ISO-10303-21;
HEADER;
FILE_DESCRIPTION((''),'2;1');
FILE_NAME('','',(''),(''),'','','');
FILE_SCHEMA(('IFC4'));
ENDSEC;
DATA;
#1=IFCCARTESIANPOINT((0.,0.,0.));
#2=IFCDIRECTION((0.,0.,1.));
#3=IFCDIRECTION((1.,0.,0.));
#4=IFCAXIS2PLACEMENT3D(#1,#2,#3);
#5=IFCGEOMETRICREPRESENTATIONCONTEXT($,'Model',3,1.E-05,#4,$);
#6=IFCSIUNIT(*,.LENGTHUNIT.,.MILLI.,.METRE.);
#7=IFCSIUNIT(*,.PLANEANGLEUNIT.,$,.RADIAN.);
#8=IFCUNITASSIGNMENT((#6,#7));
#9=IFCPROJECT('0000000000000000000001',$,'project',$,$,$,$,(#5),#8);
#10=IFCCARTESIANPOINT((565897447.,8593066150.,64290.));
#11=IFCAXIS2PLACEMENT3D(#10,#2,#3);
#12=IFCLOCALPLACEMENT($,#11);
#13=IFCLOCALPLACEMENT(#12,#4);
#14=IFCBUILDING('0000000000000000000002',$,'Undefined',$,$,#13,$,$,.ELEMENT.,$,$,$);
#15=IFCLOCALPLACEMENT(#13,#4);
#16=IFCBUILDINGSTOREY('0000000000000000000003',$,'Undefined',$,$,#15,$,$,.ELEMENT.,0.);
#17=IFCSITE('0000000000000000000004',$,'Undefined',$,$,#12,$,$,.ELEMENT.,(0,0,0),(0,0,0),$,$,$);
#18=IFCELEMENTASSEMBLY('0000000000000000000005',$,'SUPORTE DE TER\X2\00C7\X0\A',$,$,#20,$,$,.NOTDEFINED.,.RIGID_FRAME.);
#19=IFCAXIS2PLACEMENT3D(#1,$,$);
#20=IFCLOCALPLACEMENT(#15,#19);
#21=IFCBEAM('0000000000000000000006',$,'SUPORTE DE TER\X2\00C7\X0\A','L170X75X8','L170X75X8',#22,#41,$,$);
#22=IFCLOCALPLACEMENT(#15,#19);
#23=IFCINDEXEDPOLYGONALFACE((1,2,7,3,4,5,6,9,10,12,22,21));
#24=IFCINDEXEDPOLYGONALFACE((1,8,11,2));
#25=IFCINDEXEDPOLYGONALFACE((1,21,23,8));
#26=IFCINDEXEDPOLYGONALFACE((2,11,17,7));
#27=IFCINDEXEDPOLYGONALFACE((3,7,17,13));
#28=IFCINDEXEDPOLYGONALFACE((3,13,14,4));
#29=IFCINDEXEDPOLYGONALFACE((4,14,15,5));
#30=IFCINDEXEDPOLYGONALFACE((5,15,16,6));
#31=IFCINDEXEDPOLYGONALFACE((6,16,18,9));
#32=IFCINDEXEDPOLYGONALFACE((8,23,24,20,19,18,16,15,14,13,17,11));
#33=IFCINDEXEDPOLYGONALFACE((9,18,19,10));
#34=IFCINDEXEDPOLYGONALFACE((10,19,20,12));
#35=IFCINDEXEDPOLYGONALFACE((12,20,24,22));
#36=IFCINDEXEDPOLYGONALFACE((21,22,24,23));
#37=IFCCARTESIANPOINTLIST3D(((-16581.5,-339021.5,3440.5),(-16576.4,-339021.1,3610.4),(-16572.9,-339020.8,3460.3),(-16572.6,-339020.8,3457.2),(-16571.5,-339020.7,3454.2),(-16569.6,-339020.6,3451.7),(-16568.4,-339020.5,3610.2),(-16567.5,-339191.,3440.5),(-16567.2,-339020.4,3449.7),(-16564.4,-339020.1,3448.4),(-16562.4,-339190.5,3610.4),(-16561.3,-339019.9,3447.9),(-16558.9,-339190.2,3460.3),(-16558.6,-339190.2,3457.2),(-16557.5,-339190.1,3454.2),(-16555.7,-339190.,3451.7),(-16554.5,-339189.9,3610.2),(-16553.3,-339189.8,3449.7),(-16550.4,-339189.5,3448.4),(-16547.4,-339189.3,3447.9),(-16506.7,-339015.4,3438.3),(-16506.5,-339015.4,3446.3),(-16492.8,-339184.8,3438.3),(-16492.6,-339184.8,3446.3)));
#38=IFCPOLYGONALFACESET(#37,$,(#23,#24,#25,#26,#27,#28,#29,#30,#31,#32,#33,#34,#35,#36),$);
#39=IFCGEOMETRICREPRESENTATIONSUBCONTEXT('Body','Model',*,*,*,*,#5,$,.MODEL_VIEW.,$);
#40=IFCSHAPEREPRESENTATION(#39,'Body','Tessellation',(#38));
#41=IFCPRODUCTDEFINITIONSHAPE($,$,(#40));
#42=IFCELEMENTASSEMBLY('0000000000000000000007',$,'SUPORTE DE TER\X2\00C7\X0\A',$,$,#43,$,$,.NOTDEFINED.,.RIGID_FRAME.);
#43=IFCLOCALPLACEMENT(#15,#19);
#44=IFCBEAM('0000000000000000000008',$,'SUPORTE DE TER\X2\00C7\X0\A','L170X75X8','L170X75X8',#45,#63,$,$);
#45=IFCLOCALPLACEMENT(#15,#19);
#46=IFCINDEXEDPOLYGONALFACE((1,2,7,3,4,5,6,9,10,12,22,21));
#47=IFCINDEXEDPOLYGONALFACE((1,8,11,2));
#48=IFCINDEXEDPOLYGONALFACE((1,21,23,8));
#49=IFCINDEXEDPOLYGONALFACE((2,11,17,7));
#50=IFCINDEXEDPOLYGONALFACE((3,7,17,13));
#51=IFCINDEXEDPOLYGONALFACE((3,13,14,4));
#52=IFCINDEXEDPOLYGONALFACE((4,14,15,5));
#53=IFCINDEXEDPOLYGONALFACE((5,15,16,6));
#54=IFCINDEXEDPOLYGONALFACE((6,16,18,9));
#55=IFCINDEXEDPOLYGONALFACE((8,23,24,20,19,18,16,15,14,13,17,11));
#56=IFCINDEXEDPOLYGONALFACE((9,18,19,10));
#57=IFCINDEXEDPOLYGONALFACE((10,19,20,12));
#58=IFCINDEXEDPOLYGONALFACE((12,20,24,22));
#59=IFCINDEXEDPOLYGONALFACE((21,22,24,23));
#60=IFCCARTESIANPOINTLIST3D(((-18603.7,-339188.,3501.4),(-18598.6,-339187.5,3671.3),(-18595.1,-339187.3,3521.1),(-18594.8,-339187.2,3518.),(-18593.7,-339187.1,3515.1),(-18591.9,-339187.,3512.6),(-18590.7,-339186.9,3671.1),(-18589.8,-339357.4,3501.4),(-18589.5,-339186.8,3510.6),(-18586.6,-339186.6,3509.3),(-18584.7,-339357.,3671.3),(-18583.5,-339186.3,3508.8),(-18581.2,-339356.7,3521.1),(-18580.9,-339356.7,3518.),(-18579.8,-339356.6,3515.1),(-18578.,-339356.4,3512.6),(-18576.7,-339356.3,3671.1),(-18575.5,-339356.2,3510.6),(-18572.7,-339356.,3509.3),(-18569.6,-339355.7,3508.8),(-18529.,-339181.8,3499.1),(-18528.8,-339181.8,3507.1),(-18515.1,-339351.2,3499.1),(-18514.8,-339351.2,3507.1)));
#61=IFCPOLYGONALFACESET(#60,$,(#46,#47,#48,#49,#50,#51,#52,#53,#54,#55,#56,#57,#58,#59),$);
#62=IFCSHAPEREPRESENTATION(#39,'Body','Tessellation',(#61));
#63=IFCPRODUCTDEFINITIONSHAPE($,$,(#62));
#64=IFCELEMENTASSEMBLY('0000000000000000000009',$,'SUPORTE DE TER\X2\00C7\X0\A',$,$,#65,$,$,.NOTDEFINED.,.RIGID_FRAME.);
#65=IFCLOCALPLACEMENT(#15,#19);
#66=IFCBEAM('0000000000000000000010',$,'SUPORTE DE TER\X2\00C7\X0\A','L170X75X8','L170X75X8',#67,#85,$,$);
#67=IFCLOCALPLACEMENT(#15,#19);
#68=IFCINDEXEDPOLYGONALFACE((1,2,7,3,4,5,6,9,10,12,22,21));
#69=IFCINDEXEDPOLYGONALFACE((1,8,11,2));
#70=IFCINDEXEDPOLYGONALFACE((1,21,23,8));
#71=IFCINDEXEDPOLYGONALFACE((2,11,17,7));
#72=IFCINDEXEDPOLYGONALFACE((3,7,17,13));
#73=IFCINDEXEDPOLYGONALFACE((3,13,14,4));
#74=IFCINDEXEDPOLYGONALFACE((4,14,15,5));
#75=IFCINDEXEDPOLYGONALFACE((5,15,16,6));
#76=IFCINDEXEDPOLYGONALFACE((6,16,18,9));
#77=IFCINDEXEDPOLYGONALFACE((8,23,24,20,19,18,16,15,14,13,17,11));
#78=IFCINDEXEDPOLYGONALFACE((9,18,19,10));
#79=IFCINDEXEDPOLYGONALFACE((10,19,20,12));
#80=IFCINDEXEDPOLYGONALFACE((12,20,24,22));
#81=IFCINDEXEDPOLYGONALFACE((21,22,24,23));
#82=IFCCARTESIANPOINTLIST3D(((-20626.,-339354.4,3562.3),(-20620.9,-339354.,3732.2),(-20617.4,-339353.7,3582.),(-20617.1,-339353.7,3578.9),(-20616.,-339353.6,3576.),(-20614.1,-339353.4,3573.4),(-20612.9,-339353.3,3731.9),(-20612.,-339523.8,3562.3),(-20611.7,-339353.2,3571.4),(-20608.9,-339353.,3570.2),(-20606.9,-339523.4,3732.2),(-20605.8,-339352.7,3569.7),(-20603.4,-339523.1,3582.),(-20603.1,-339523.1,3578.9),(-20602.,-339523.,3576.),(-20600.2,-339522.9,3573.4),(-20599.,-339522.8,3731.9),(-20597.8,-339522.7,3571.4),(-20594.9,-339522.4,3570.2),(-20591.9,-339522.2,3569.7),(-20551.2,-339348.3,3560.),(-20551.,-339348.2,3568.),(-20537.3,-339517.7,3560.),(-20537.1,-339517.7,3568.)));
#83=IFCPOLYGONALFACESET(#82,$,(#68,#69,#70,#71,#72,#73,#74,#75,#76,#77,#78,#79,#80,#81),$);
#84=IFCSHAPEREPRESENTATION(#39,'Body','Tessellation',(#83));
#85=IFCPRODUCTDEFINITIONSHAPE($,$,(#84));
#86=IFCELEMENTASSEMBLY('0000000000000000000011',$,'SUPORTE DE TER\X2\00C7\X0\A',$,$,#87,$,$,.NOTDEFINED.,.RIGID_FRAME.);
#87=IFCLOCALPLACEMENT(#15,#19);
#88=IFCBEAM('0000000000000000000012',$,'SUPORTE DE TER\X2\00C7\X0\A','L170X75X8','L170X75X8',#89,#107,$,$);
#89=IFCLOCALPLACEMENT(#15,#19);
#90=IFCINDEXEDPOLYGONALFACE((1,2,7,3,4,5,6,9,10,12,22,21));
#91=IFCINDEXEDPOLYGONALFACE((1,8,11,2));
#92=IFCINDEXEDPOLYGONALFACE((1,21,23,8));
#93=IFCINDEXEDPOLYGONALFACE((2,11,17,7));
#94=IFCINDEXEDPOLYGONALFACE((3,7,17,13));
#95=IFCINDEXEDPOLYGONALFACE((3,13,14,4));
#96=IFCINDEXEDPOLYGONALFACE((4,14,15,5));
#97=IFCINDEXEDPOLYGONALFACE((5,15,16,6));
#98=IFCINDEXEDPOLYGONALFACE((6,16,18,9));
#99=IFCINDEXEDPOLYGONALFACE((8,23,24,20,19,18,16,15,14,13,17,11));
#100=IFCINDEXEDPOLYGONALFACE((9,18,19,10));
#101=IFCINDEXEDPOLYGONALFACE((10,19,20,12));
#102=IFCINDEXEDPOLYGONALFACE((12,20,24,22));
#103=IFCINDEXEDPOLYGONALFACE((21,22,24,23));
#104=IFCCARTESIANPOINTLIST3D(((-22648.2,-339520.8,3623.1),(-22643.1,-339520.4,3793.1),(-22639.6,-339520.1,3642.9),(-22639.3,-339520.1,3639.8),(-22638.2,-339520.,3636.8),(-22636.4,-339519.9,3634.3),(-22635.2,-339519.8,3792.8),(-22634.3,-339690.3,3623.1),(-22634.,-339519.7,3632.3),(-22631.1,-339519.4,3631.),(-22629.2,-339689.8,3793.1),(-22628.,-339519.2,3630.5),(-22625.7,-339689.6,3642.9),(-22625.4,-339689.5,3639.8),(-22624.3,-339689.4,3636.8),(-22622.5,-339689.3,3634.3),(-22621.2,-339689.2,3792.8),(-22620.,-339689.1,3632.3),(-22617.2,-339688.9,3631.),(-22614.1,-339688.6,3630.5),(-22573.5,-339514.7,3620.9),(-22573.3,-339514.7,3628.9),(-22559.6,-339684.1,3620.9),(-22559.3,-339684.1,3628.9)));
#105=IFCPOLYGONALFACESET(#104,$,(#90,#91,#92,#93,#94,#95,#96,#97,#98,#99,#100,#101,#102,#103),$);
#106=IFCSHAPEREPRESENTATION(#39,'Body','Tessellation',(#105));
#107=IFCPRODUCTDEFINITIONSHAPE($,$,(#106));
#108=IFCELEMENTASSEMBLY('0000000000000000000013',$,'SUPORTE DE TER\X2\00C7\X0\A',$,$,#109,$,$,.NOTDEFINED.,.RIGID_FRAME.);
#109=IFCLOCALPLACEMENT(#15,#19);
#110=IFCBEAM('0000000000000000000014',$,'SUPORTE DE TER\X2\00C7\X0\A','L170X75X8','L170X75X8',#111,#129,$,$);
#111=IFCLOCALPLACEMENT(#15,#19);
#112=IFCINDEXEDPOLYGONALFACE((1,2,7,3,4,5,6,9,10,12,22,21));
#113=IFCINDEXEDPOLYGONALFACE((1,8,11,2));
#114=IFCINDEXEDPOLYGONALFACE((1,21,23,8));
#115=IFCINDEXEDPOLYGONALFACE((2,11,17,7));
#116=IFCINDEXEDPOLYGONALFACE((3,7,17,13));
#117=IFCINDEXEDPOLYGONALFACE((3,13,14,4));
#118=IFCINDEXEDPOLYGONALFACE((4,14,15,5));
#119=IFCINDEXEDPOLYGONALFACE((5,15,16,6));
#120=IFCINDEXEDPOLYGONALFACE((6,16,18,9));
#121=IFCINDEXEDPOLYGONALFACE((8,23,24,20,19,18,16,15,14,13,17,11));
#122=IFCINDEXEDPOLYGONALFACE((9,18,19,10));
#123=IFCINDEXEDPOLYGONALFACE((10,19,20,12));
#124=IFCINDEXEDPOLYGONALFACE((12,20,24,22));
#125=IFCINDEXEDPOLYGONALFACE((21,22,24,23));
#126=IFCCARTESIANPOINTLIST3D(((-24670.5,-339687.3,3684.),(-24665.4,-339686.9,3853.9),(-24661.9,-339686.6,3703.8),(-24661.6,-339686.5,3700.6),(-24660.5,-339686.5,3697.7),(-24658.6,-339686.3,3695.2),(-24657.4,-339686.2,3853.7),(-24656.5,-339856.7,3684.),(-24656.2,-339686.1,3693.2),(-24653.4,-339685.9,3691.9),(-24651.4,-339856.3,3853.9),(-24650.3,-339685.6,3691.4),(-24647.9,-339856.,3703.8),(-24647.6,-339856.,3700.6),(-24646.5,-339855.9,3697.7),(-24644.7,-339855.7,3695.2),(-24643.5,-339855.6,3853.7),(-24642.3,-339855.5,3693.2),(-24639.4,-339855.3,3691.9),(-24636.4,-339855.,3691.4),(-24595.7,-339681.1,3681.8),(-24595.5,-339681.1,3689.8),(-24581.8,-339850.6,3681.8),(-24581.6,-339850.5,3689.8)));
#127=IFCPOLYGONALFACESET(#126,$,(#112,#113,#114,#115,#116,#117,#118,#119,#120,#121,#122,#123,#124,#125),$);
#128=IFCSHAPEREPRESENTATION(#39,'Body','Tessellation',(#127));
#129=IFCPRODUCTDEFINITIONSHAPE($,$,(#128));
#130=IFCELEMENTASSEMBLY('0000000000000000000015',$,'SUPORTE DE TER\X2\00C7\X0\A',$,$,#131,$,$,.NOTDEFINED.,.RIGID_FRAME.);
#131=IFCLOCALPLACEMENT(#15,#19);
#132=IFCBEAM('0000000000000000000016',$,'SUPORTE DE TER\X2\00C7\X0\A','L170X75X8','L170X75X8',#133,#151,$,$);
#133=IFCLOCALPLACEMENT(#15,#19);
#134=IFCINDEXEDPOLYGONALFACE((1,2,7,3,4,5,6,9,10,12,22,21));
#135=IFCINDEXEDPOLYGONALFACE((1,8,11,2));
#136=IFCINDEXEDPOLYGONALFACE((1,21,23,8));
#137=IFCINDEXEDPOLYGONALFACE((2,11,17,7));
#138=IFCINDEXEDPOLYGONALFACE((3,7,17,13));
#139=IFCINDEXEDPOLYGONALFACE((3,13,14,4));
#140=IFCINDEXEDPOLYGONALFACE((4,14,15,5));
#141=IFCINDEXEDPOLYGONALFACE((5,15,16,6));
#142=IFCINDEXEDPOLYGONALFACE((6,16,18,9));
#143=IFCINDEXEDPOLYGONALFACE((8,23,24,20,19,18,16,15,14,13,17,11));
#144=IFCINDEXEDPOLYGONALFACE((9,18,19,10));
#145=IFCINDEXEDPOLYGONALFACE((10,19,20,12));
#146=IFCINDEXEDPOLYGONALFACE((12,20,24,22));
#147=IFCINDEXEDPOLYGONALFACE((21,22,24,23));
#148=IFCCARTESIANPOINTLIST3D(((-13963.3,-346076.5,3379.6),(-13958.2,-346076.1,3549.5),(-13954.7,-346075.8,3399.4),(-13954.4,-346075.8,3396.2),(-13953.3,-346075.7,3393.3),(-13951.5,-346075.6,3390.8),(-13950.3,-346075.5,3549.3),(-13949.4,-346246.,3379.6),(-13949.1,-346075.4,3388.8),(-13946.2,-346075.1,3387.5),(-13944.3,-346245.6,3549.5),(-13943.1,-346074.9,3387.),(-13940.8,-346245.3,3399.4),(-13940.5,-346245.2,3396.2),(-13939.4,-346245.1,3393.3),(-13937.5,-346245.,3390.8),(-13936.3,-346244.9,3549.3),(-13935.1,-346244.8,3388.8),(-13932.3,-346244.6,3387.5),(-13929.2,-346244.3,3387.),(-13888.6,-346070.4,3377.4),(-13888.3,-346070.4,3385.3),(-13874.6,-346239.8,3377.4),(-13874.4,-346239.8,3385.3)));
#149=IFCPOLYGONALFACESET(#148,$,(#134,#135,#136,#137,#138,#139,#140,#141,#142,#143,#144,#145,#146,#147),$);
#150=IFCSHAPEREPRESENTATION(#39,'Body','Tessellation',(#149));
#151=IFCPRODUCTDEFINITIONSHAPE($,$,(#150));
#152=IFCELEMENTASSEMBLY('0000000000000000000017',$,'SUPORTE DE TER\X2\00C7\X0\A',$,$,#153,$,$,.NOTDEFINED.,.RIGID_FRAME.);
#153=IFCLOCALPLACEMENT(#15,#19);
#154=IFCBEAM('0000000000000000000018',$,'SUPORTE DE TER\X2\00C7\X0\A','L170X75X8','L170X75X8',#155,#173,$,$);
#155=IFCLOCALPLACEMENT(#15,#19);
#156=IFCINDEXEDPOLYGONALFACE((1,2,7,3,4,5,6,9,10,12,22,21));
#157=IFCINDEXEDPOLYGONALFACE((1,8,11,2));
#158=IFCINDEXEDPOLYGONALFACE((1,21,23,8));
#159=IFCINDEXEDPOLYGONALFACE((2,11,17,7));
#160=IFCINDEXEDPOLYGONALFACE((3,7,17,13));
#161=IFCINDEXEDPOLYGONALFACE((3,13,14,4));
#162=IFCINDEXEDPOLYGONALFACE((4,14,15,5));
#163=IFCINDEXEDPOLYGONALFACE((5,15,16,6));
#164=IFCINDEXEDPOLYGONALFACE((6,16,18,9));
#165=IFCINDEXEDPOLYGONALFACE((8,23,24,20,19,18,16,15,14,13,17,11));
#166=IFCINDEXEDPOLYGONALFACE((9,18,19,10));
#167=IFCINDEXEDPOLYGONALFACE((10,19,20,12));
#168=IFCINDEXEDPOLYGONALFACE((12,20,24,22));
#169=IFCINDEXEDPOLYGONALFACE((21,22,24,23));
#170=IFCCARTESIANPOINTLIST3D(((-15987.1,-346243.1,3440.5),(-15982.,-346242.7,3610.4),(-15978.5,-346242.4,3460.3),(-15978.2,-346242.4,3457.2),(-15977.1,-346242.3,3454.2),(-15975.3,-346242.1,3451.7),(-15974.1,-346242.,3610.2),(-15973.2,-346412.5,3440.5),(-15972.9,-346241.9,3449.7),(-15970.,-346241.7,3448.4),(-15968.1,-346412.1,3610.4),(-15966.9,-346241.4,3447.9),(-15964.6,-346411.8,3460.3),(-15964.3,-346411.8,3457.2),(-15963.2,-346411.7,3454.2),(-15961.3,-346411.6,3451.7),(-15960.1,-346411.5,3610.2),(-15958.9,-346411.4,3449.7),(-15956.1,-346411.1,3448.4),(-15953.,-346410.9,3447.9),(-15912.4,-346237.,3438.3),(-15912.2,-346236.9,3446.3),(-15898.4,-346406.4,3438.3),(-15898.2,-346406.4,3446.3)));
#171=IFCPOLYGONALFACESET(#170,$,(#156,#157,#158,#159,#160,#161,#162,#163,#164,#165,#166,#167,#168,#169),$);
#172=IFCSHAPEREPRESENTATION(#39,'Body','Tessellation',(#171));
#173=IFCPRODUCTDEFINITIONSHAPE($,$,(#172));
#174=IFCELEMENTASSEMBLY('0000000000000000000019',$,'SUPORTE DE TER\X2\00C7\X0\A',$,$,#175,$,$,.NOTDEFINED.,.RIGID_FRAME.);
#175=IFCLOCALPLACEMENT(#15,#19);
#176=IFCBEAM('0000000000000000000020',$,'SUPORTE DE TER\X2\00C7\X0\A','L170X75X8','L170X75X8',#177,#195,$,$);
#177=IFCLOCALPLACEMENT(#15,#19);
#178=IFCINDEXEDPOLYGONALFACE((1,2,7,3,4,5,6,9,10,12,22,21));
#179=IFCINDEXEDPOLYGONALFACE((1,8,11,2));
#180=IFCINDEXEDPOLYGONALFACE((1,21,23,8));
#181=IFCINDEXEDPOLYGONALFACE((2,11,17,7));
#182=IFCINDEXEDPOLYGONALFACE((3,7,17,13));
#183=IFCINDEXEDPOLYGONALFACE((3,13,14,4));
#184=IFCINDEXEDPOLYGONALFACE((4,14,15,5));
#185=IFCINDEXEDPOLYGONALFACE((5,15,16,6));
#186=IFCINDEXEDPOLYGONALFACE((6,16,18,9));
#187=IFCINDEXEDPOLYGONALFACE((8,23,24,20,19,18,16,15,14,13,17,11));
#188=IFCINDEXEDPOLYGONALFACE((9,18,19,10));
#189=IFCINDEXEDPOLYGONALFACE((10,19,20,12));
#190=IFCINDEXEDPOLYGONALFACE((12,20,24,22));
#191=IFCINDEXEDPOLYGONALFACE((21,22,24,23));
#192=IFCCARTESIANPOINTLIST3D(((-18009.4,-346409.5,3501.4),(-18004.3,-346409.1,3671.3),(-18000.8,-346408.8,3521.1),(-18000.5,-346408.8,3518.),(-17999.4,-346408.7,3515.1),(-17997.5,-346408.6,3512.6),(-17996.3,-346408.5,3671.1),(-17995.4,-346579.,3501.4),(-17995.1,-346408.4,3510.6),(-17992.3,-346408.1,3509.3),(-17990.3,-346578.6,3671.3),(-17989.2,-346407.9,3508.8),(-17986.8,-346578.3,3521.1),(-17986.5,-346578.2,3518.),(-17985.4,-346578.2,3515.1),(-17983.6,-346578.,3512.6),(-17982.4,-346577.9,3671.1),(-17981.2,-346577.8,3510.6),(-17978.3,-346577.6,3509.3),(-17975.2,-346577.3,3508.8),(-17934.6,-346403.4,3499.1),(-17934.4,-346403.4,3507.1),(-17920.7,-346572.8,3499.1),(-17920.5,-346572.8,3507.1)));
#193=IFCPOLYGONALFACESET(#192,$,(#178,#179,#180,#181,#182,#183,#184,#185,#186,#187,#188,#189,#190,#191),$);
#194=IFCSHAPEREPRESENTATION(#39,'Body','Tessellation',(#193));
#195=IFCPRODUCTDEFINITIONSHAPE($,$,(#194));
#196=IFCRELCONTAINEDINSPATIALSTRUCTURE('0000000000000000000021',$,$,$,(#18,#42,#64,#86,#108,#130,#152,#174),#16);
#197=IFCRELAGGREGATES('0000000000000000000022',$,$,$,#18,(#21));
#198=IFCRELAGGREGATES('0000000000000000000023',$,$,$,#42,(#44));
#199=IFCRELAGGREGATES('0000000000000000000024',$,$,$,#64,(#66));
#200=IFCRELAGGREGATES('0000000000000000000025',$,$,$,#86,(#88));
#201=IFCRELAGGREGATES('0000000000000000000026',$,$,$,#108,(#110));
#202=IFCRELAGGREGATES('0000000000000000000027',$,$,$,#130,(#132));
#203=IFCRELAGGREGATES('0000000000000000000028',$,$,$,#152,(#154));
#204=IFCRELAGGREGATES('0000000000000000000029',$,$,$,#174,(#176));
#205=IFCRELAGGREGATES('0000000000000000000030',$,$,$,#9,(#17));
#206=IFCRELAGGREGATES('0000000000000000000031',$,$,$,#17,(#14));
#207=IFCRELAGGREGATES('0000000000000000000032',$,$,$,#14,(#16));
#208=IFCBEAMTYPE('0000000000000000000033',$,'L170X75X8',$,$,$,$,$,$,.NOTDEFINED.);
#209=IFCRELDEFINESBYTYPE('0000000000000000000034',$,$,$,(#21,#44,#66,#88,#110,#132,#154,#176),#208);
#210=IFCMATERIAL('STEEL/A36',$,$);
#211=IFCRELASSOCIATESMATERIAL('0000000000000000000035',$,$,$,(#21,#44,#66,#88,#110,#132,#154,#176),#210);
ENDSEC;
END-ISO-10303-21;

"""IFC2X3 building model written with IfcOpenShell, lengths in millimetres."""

from ifc_helpers import new_model, si_unit, frame, origin_with_axes, origin_2d_with_axis, place, context, subcontext, project, spatial, l_section, extrude, material, type_object, element, aggregate, save


model = new_model("IFC2X3")

# Units and contexts
model_context = context("Model", 3, precision=1e-05, world=origin_with_axes())
body_context = subcontext(model_context, "Body", "Model", "MODEL_VIEW")
ifc_project = project(units=[si_unit("LENGTHUNIT", "METRE", prefix="MILLI"), si_unit("PLANEANGLEUNIT", "RADIAN")], contexts=[model_context])

# Site, building, storey
site_placement = place(None, frame((565897447.0, 8593066150.0, 64290.0), z_axis=(0.0, 0.0, 1.0), x_axis=(1.0, 0.0, 0.0)))
site = spatial("IfcSite", under=ifc_project, at=site_placement, Name="Undefined", CompositionType="ELEMENT", RefLatitude=(0, 0, 0), RefLongitude=(0, 0, 0))
building_placement = place(site_placement, origin_with_axes())
building = spatial("IfcBuilding", under=site, at=building_placement, Name="Undefined", CompositionType="ELEMENT")
storey_placement = place(building_placement, origin_with_axes())
storey = spatial("IfcBuildingStorey", under=building, at=storey_placement, Name="Undefined", CompositionType="ELEMENT", Elevation=0.0)

# Element assemblies, beams
assembly_1_placement = place(storey_placement, origin_with_axes())
assembly_1 = element("IfcElementAssembly", 1, at=assembly_1_placement, inside=storey, Name="SUPORTE DE TERÇA", AssemblyPlace="NOTDEFINED", PredefinedType="RIGID_FRAME")
ifc_material_1 = material(Name="STEEL/A36")
beam_type_1 = type_object("IfcBeamType", Name="L170X75X8", PredefinedType="NOTDEFINED")
beam_1_placement = place(assembly_1_placement, frame((-16527.6, -339187.7, 3524.4), z_axis=(0.029885, 0.00246, 0.99955), x_axis=(-0.082025, 0.99663, 0.0)))
beam_1 = element("IfcBeam", 2, at=beam_1_placement, type_object=beam_type_1, material=ifc_material_1, Name="SUPORTE DE TERÇA", Description="L170X75X8", ObjectType="L170X75X8", context=body_context, shape_type="SweptSolid", body=[
    extrude(l_section(Depth=170.0, Width=75.0, Thickness=8.0, FilletRadius=12.0, at=origin_2d_with_axis()), frame((170.0, 0.0, 0.0), z_axis=(-1.0, 0.0, 0.0), x_axis=(0.0, -1.0, 0.0)), (0.0, 0.0, 1.0), 170.0),
])
aggregate(assembly_1, [beam_1])
assembly_2_placement = place(storey_placement, origin_with_axes())
assembly_2 = element("IfcElementAssembly", 3, at=assembly_2_placement, inside=storey, Name="SUPORTE DE TERÇA", AssemblyPlace="NOTDEFINED", PredefinedType="RIGID_FRAME")
beam_2_placement = place(assembly_2_placement, frame((-18549.9, -339354.1, 3585.2), z_axis=(0.029885, 0.00246, 0.99955), x_axis=(-0.082025, 0.99663, 0.0)))
beam_2 = element("IfcBeam", 4, at=beam_2_placement, type_object=beam_type_1, material=ifc_material_1, Name="SUPORTE DE TERÇA", Description="L170X75X8", ObjectType="L170X75X8", context=body_context, shape_type="SweptSolid", body=[
    extrude(l_section(Depth=170.0, Width=75.0, Thickness=8.0, FilletRadius=12.0, at=origin_2d_with_axis()), frame((170.0, 0.0, 0.0), z_axis=(-1.0, 0.0, 0.0), x_axis=(0.0, -1.0, 0.0)), (0.0, 0.0, 1.0), 170.0),
])
aggregate(assembly_2, [beam_2])
assembly_3_placement = place(storey_placement, origin_with_axes())
assembly_3 = element("IfcElementAssembly", 5, at=assembly_3_placement, inside=storey, Name="SUPORTE DE TERÇA", AssemblyPlace="NOTDEFINED", PredefinedType="RIGID_FRAME")
beam_3_placement = place(assembly_3_placement, frame((-20572.1, -339520.5, 3646.1), z_axis=(0.029885, 0.00246, 0.99955), x_axis=(-0.082025, 0.99663, 0.0)))
beam_3 = element("IfcBeam", 6, at=beam_3_placement, type_object=beam_type_1, material=ifc_material_1, Name="SUPORTE DE TERÇA", Description="L170X75X8", ObjectType="L170X75X8", context=body_context, shape_type="SweptSolid", body=[
    extrude(l_section(Depth=170.0, Width=75.0, Thickness=8.0, FilletRadius=12.0, at=origin_2d_with_axis()), frame((170.0, 0.0, 0.0), z_axis=(-1.0, 0.0, 0.0), x_axis=(0.0, -1.0, 0.0)), (0.0, 0.0, 1.0), 170.0),
])
aggregate(assembly_3, [beam_3])
assembly_4_placement = place(storey_placement, origin_with_axes())
assembly_4 = element("IfcElementAssembly", 7, at=assembly_4_placement, inside=storey, Name="SUPORTE DE TERÇA", AssemblyPlace="NOTDEFINED", PredefinedType="RIGID_FRAME")
beam_4_placement = place(assembly_4_placement, frame((-22594.4, -339687.0, 3707.0), z_axis=(0.029885, 0.00246, 0.99955), x_axis=(-0.082025, 0.99663, 0.0)))
beam_4 = element("IfcBeam", 8, at=beam_4_placement, type_object=beam_type_1, material=ifc_material_1, Name="SUPORTE DE TERÇA", Description="L170X75X8", ObjectType="L170X75X8", context=body_context, shape_type="SweptSolid", body=[
    extrude(l_section(Depth=170.0, Width=75.0, Thickness=8.0, FilletRadius=12.0, at=origin_2d_with_axis()), frame((170.0, 0.0, 0.0), z_axis=(-1.0, 0.0, 0.0), x_axis=(0.0, -1.0, 0.0)), (0.0, 0.0, 1.0), 170.0),
])
aggregate(assembly_4, [beam_4])
assembly_5_placement = place(storey_placement, origin_with_axes())
assembly_5 = element("IfcElementAssembly", 9, at=assembly_5_placement, inside=storey, Name="SUPORTE DE TERÇA", AssemblyPlace="NOTDEFINED", PredefinedType="RIGID_FRAME")
beam_5_placement = place(assembly_5_placement, frame((-24616.6, -339853.4, 3767.8), z_axis=(0.029885, 0.00246, 0.99955), x_axis=(-0.082025, 0.99663, 0.0)))
beam_5 = element("IfcBeam", 10, at=beam_5_placement, type_object=beam_type_1, material=ifc_material_1, Name="SUPORTE DE TERÇA", Description="L170X75X8", ObjectType="L170X75X8", context=body_context, shape_type="SweptSolid", body=[
    extrude(l_section(Depth=170.0, Width=75.0, Thickness=8.0, FilletRadius=12.0, at=origin_2d_with_axis()), frame((170.0, 0.0, 0.0), z_axis=(-1.0, 0.0, 0.0), x_axis=(0.0, -1.0, 0.0)), (0.0, 0.0, 1.0), 170.0),
])
aggregate(assembly_5, [beam_5])
assembly_6_placement = place(storey_placement, origin_with_axes())
assembly_6 = element("IfcElementAssembly", 11, at=assembly_6_placement, inside=storey, Name="SUPORTE DE TERÇA", AssemblyPlace="NOTDEFINED", PredefinedType="RIGID_FRAME")
beam_6_placement = place(assembly_6_placement, frame((-13909.5, -346242.7, 3463.4), z_axis=(0.029885, 0.00246, 0.99955), x_axis=(-0.082025, 0.99663, 0.0)))
beam_6 = element("IfcBeam", 12, at=beam_6_placement, type_object=beam_type_1, material=ifc_material_1, Name="SUPORTE DE TERÇA", Description="L170X75X8", ObjectType="L170X75X8", context=body_context, shape_type="SweptSolid", body=[
    extrude(l_section(Depth=170.0, Width=75.0, Thickness=8.0, FilletRadius=12.0, at=origin_2d_with_axis()), frame((170.0, 0.0, 0.0), z_axis=(-1.0, 0.0, 0.0), x_axis=(0.0, -1.0, 0.0)), (0.0, 0.0, 1.0), 170.0),
])
aggregate(assembly_6, [beam_6])
assembly_7_placement = place(storey_placement, origin_with_axes())
assembly_7 = element("IfcElementAssembly", 13, at=assembly_7_placement, inside=storey, Name="SUPORTE DE TERÇA", AssemblyPlace="NOTDEFINED", PredefinedType="RIGID_FRAME")
beam_7_placement = place(assembly_7_placement, frame((-15933.3, -346409.3, 3524.4), z_axis=(0.029885, 0.00246, 0.99955), x_axis=(-0.082025, 0.99663, 0.0)))
beam_7 = element("IfcBeam", 14, at=beam_7_placement, type_object=beam_type_1, material=ifc_material_1, Name="SUPORTE DE TERÇA", Description="L170X75X8", ObjectType="L170X75X8", context=body_context, shape_type="SweptSolid", body=[
    extrude(l_section(Depth=170.0, Width=75.0, Thickness=8.0, FilletRadius=12.0, at=origin_2d_with_axis()), frame((170.0, 0.0, 0.0), z_axis=(-1.0, 0.0, 0.0), x_axis=(0.0, -1.0, 0.0)), (0.0, 0.0, 1.0), 170.0),
])
aggregate(assembly_7, [beam_7])
assembly_8_placement = place(storey_placement, origin_with_axes())
assembly_8 = element("IfcElementAssembly", 15, at=assembly_8_placement, inside=storey, Name="SUPORTE DE TERÇA", AssemblyPlace="NOTDEFINED", PredefinedType="RIGID_FRAME")
beam_8_placement = place(assembly_8_placement, frame((-17955.5, -346575.7, 3585.2), z_axis=(0.029885, 0.00246, 0.99955), x_axis=(-0.082025, 0.99663, 0.0)))
beam_8 = element("IfcBeam", 16, at=beam_8_placement, type_object=beam_type_1, material=ifc_material_1, Name="SUPORTE DE TERÇA", Description="L170X75X8", ObjectType="L170X75X8", context=body_context, shape_type="SweptSolid", body=[
    extrude(l_section(Depth=170.0, Width=75.0, Thickness=8.0, FilletRadius=12.0, at=origin_2d_with_axis()), frame((170.0, 0.0, 0.0), z_axis=(-1.0, 0.0, 0.0), x_axis=(0.0, -1.0, 0.0)), (0.0, 0.0, 1.0), 170.0),
])
aggregate(assembly_8, [beam_8])

save(model, "model.ifc")
